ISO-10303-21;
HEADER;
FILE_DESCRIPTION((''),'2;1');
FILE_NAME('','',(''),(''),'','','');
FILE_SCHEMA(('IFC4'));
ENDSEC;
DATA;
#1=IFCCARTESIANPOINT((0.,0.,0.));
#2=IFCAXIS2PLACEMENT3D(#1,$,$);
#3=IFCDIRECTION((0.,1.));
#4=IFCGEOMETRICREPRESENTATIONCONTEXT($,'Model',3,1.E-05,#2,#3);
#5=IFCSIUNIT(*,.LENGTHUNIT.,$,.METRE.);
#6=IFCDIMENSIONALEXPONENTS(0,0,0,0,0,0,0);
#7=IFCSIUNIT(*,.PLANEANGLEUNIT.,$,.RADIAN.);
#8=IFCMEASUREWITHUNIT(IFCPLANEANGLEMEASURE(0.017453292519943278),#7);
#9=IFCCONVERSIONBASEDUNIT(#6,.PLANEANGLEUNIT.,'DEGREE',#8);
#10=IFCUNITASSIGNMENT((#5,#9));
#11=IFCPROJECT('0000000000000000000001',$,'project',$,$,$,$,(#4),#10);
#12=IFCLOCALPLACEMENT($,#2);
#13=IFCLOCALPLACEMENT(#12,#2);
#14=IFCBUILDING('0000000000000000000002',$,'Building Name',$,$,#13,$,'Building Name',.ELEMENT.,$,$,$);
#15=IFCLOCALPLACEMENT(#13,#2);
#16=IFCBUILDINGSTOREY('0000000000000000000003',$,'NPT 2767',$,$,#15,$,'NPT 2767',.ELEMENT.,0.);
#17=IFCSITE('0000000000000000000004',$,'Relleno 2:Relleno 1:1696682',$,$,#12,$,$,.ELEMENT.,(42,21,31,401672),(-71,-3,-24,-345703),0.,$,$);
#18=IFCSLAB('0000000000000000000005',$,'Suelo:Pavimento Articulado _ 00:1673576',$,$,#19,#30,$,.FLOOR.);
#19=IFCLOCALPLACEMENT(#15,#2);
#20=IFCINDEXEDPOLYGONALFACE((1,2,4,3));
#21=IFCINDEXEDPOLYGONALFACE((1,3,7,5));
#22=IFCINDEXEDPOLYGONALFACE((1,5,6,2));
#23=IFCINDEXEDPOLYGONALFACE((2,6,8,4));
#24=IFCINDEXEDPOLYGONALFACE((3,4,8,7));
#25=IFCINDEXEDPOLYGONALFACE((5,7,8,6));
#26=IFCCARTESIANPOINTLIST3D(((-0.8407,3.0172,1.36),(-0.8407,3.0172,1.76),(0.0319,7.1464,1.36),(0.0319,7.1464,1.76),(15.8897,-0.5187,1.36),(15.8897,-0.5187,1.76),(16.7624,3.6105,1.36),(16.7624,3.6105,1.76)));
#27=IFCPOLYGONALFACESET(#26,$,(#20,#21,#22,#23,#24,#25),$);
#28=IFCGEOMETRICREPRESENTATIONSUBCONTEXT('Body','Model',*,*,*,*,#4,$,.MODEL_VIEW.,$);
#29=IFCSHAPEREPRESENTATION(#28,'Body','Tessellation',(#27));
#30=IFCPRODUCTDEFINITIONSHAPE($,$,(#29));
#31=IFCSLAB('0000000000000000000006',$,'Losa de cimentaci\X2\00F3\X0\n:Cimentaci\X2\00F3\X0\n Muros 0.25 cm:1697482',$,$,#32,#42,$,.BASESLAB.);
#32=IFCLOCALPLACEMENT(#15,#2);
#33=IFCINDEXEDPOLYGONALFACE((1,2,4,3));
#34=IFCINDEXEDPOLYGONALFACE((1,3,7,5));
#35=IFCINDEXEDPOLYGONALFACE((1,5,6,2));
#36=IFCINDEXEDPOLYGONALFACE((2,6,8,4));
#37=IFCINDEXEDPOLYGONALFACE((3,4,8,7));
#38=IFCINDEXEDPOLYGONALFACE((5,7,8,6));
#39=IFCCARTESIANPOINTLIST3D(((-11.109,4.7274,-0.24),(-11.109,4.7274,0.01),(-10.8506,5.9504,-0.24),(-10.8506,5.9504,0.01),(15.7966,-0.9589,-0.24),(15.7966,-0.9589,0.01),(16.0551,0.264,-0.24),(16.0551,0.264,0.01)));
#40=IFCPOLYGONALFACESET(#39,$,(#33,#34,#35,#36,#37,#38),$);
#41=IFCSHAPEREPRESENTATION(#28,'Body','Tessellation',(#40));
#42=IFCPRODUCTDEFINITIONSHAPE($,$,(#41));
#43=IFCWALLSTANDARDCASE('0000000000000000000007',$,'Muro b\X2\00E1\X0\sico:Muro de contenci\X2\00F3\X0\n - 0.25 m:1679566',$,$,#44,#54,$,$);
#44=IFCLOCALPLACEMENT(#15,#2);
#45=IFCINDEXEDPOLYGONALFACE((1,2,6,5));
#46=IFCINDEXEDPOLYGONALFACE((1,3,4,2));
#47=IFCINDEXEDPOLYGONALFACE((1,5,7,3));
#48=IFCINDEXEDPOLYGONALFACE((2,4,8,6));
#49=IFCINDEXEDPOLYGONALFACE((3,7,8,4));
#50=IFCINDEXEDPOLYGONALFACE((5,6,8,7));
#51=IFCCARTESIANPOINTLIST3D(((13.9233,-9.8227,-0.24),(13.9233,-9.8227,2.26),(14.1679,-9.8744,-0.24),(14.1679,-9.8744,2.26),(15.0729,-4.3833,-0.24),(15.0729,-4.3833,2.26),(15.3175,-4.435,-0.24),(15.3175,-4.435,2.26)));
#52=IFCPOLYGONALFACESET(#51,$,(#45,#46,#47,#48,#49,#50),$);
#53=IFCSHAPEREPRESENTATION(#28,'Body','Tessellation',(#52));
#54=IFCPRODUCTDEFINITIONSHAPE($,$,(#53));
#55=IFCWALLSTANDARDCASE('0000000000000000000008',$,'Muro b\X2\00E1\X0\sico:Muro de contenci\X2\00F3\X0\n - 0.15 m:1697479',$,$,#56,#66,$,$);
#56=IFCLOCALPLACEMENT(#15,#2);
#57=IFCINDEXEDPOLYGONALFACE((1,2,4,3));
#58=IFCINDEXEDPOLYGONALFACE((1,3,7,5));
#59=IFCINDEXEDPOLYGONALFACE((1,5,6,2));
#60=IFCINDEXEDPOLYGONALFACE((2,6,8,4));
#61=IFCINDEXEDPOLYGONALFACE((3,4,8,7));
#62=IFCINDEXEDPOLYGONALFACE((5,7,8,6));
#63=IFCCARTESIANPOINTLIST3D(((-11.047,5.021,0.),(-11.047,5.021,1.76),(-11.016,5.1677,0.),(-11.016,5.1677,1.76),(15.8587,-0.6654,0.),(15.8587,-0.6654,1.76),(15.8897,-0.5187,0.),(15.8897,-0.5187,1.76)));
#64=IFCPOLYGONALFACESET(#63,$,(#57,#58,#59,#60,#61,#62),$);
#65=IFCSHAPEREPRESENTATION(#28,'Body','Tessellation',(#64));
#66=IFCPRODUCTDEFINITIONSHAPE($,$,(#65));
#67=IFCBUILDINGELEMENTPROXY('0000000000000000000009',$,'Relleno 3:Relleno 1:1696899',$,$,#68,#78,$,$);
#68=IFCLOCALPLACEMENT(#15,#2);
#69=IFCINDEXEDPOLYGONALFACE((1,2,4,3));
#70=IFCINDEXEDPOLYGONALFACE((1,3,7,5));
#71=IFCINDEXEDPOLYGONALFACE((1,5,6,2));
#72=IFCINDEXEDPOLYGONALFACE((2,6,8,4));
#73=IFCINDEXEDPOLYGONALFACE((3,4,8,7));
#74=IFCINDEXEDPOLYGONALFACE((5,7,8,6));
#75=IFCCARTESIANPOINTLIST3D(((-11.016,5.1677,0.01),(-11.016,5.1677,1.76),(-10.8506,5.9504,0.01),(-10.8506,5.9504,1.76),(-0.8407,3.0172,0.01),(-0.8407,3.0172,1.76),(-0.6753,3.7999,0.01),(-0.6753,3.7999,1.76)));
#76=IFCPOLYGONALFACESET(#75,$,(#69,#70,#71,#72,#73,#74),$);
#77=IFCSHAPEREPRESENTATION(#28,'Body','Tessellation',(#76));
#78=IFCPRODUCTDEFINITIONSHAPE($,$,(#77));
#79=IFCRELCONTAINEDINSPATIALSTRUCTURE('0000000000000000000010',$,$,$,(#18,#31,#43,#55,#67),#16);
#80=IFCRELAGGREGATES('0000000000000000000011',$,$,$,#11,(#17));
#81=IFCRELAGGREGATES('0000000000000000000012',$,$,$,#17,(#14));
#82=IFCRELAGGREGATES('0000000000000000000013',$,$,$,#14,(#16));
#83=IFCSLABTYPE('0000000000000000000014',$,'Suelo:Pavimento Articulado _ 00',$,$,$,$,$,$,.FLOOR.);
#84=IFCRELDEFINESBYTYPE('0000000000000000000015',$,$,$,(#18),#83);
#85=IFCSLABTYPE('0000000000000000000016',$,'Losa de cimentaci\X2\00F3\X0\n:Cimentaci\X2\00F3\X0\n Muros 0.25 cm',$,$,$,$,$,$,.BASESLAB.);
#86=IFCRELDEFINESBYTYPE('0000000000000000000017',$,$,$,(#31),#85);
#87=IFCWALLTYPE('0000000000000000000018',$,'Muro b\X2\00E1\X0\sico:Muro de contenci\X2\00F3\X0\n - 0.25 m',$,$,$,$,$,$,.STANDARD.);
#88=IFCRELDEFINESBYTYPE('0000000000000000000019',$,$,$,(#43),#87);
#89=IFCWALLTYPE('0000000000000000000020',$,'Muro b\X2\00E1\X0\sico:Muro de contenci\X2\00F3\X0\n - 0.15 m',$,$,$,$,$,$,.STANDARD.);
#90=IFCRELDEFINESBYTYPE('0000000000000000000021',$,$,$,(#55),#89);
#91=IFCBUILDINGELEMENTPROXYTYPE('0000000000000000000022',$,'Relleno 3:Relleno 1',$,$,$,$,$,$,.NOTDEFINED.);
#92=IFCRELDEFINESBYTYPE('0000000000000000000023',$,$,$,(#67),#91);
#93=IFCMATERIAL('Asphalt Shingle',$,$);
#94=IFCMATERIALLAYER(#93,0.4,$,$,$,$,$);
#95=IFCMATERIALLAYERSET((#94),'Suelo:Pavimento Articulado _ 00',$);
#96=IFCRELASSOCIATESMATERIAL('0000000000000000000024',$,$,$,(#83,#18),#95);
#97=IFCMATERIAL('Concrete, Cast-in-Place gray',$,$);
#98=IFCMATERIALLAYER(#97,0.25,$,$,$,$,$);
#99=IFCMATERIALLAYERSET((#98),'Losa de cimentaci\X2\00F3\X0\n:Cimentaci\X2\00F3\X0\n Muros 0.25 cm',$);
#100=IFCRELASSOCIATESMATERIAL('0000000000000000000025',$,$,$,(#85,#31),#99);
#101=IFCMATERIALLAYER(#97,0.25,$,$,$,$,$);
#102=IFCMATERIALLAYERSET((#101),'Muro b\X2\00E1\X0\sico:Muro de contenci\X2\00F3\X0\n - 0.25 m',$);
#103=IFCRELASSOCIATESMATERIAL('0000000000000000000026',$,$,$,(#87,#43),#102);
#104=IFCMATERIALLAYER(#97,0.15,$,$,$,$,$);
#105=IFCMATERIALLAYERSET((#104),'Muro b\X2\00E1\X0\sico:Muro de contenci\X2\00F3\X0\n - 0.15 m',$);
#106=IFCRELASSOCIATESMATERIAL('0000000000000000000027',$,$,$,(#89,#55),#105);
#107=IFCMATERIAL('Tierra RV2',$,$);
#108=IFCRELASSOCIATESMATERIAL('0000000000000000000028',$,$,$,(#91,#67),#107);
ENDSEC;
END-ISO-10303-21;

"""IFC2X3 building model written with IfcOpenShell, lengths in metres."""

from ifc_helpers import new_model, entity, si_unit, converted_unit, direction, frame, frame_2d, origin, origin_2d_with_axis, place, context, subcontext, project, spatial, rectangle, extrude, source, transform, mapped, material, layer, layer_set, layer_usage, type_object, type_shapes, element, save


model = new_model("IFC2X3")

# Units and contexts
model_context = context("Model", 3, precision=1e-05, world=origin(), true_north=direction((0.0, 1.0)))
body_context = subcontext(model_context, "Body", "Model", "MODEL_VIEW")
ifc_project = project(units=[si_unit("LENGTHUNIT", "METRE"), converted_unit("PLANEANGLEUNIT", "DEGREE", entity("IfcPlaneAngleMeasure", 0.017453292519943278), si_unit("PLANEANGLEUNIT", "RADIAN"), dimensions=[0, 0, 0, 0, 0, 0, 0])], contexts=[model_context])

# Site, building, storey
site_placement = place(None, origin())
site = spatial("IfcSite", under=ifc_project, at=site_placement, Name="Relleno 2:Relleno 1:1696682", CompositionType="ELEMENT", RefLatitude=(42, 21, 31, 401672), RefLongitude=(-71, -3, -24, -345703), RefElevation=0.0)
building_placement = place(site_placement, origin())
building = spatial("IfcBuilding", under=site, at=building_placement, Name="Building Name", LongName="Building Name", CompositionType="ELEMENT")
storey_placement = place(building_placement, origin())
storey = spatial("IfcBuildingStorey", under=building, at=storey_placement, Name="NPT 2767", LongName="NPT 2767", CompositionType="ELEMENT", Elevation=0.0)

# Slabs
ifc_material_1 = material(Name="Concrete, Cast-in-Place gray")
ifc_material_2 = material(Name="Asphalt Shingle")
ifc_layer_1 = layer(ifc_material_2, 0.4)
ifc_layer_set_1 = layer_set([ifc_layer_1], Name="Suelo:Pavimento Articulado _ 00")
ifc_layer_usage_1 = layer_usage(ifc_layer_set_1, "AXIS3", "POSITIVE", 0.0)
slab_type_1 = type_object("IfcSlabType", Name="Suelo:Pavimento Articulado _ 00", PredefinedType="FLOOR", material=ifc_layer_set_1)
slab_1_placement = place(storey_placement, origin())
element("IfcSlab", 1, at=slab_1_placement, inside=storey, type_object=slab_type_1, material=ifc_layer_usage_1, Name="Suelo:Pavimento Articulado _ 00:1673576", PredefinedType="FLOOR", context=body_context, shape_type="SweptSolid", body=[
    extrude(rectangle(XDim=17.1, YDim=4.2204, at=frame_2d((0.0, 0.0), x_axis=(1.0, 0.0))), frame((7.9608, 3.3138, 1.76), z_axis=(0.0, 0.0, -1.0), x_axis=(0.978388, -0.206778, 0.0)), (0.0, 0.0, 1.0), 0.4),
])
ifc_layer_2 = layer(ifc_material_1, 0.25)
ifc_layer_set_2 = layer_set([ifc_layer_2], Name="Losa de cimentación:Cimentación Muros 0.25 cm")
ifc_layer_usage_2 = layer_usage(ifc_layer_set_2, "AXIS3", "POSITIVE", 0.0)
slab_type_2 = type_object("IfcSlabType", Name="Losa de cimentación:Cimentación Muros 0.25 cm", PredefinedType="BASESLAB", material=ifc_layer_set_2)
slab_2_placement = place(storey_placement, origin())
element("IfcSlab", 2, at=slab_2_placement, inside=storey, type_object=slab_type_2, material=ifc_layer_usage_2, Name="Losa de cimentación:Cimentación Muros 0.25 cm:1697482", PredefinedType="BASESLAB", context=body_context, shape_type="SweptSolid", body=[
    extrude(rectangle(XDim=27.5, YDim=1.25, at=frame_2d((0.0, 0.0), x_axis=(1.0, 0.0))), frame((2.473, 2.4957, 0.01), z_axis=(0.0, 0.0, -1.0), x_axis=(0.978388, -0.206778, 0.0)), (0.0, 0.0, 1.0), 0.25),
])

# Walls
ifc_layer_3 = layer(ifc_material_1, 0.25)
ifc_layer_set_3 = layer_set([ifc_layer_3], Name="Muro básico:Muro de contención - 0.25 m")
ifc_layer_usage_3 = layer_usage(ifc_layer_set_3, "AXIS2", "NEGATIVE", 0.125)
wall_type_1 = type_object("IfcWallType", Name="Muro básico:Muro de contención - 0.25 m", PredefinedType="STANDARD", material=ifc_layer_set_3)
wall_1_placement = place(storey_placement, frame((15.1952, -4.4092, -0.24), z_axis=(0.0, 0.0, 1.0), x_axis=(-0.206778, -0.978388, 0.0)))
element("IfcWallStandardCase", 3, at=wall_1_placement, inside=storey, type_object=wall_type_1, material=ifc_layer_usage_3, Name="Muro básico:Muro de contención - 0.25 m:1679566", context=body_context, shape_type="SweptSolid", body=[
    extrude(rectangle(XDim=5.5595, YDim=0.25, at=frame_2d((2.7798, 0.0), x_axis=(-1.0, 0.0))), origin(), (0.0, 0.0, 1.0), 2.5),
])
ifc_layer_4 = layer(ifc_material_1, 0.15)
ifc_layer_set_4 = layer_set([ifc_layer_4], Name="Muro básico:Muro de contención - 0.15 m")
ifc_layer_usage_4 = layer_usage(ifc_layer_set_4, "AXIS2", "NEGATIVE", 0.075)
wall_type_2 = type_object("IfcWallType", Name="Muro básico:Muro de contención - 0.15 m", PredefinedType="STANDARD", material=ifc_layer_set_4)
wall_2_placement = place(storey_placement, frame((-11.0315, 5.0943, 0.0), z_axis=(0.0, 0.0, 1.0), x_axis=(0.978388, -0.206778, 0.0)))
element("IfcWallStandardCase", 4, at=wall_2_placement, inside=storey, type_object=wall_type_2, material=ifc_layer_usage_4, Name="Muro básico:Muro de contención - 0.15 m:1697479", context=body_context, shape_type="SweptSolid", body=[
    extrude(rectangle(XDim=27.5, YDim=0.15, at=frame_2d((13.75, 0.0), x_axis=(-1.0, 0.0))), origin(), (0.0, 0.0, 1.0), 1.76),
])

# Building element proxy
ifc_material_3 = material(Name="Tierra RV2")
building_element_proxy_type_1 = type_object("IfcBuildingElementProxyType", Name="Relleno 3:Relleno 1", PredefinedType="NOTDEFINED", material=ifc_material_3)
shared_shape_1 = source(origin(), body_context, "Body", "SweptSolid", [
    extrude(rectangle(XDim=10.4, YDim=0.8, at=origin_2d_with_axis()), frame((-5.8456, 4.4838, 0.01), z_axis=(0.0, 0.0, 1.0), x_axis=(0.978388, -0.206778, 0.0)), (0.0, 0.0, 1.0), 1.75),
])
type_shapes(building_element_proxy_type_1, [shared_shape_1])
proxy_1_placement = place(storey_placement, origin())
element("IfcBuildingElementProxy", 5, at=proxy_1_placement, inside=storey, type_object=building_element_proxy_type_1, material=ifc_material_3, Name="Relleno 3:Relleno 1:1696899", context=body_context, shape_type="MappedRepresentation", body=[
    mapped(shared_shape_1, transform((0.0, 0.0, 0.0), scale=1.0)),
])

save(model, "model.ifc")
